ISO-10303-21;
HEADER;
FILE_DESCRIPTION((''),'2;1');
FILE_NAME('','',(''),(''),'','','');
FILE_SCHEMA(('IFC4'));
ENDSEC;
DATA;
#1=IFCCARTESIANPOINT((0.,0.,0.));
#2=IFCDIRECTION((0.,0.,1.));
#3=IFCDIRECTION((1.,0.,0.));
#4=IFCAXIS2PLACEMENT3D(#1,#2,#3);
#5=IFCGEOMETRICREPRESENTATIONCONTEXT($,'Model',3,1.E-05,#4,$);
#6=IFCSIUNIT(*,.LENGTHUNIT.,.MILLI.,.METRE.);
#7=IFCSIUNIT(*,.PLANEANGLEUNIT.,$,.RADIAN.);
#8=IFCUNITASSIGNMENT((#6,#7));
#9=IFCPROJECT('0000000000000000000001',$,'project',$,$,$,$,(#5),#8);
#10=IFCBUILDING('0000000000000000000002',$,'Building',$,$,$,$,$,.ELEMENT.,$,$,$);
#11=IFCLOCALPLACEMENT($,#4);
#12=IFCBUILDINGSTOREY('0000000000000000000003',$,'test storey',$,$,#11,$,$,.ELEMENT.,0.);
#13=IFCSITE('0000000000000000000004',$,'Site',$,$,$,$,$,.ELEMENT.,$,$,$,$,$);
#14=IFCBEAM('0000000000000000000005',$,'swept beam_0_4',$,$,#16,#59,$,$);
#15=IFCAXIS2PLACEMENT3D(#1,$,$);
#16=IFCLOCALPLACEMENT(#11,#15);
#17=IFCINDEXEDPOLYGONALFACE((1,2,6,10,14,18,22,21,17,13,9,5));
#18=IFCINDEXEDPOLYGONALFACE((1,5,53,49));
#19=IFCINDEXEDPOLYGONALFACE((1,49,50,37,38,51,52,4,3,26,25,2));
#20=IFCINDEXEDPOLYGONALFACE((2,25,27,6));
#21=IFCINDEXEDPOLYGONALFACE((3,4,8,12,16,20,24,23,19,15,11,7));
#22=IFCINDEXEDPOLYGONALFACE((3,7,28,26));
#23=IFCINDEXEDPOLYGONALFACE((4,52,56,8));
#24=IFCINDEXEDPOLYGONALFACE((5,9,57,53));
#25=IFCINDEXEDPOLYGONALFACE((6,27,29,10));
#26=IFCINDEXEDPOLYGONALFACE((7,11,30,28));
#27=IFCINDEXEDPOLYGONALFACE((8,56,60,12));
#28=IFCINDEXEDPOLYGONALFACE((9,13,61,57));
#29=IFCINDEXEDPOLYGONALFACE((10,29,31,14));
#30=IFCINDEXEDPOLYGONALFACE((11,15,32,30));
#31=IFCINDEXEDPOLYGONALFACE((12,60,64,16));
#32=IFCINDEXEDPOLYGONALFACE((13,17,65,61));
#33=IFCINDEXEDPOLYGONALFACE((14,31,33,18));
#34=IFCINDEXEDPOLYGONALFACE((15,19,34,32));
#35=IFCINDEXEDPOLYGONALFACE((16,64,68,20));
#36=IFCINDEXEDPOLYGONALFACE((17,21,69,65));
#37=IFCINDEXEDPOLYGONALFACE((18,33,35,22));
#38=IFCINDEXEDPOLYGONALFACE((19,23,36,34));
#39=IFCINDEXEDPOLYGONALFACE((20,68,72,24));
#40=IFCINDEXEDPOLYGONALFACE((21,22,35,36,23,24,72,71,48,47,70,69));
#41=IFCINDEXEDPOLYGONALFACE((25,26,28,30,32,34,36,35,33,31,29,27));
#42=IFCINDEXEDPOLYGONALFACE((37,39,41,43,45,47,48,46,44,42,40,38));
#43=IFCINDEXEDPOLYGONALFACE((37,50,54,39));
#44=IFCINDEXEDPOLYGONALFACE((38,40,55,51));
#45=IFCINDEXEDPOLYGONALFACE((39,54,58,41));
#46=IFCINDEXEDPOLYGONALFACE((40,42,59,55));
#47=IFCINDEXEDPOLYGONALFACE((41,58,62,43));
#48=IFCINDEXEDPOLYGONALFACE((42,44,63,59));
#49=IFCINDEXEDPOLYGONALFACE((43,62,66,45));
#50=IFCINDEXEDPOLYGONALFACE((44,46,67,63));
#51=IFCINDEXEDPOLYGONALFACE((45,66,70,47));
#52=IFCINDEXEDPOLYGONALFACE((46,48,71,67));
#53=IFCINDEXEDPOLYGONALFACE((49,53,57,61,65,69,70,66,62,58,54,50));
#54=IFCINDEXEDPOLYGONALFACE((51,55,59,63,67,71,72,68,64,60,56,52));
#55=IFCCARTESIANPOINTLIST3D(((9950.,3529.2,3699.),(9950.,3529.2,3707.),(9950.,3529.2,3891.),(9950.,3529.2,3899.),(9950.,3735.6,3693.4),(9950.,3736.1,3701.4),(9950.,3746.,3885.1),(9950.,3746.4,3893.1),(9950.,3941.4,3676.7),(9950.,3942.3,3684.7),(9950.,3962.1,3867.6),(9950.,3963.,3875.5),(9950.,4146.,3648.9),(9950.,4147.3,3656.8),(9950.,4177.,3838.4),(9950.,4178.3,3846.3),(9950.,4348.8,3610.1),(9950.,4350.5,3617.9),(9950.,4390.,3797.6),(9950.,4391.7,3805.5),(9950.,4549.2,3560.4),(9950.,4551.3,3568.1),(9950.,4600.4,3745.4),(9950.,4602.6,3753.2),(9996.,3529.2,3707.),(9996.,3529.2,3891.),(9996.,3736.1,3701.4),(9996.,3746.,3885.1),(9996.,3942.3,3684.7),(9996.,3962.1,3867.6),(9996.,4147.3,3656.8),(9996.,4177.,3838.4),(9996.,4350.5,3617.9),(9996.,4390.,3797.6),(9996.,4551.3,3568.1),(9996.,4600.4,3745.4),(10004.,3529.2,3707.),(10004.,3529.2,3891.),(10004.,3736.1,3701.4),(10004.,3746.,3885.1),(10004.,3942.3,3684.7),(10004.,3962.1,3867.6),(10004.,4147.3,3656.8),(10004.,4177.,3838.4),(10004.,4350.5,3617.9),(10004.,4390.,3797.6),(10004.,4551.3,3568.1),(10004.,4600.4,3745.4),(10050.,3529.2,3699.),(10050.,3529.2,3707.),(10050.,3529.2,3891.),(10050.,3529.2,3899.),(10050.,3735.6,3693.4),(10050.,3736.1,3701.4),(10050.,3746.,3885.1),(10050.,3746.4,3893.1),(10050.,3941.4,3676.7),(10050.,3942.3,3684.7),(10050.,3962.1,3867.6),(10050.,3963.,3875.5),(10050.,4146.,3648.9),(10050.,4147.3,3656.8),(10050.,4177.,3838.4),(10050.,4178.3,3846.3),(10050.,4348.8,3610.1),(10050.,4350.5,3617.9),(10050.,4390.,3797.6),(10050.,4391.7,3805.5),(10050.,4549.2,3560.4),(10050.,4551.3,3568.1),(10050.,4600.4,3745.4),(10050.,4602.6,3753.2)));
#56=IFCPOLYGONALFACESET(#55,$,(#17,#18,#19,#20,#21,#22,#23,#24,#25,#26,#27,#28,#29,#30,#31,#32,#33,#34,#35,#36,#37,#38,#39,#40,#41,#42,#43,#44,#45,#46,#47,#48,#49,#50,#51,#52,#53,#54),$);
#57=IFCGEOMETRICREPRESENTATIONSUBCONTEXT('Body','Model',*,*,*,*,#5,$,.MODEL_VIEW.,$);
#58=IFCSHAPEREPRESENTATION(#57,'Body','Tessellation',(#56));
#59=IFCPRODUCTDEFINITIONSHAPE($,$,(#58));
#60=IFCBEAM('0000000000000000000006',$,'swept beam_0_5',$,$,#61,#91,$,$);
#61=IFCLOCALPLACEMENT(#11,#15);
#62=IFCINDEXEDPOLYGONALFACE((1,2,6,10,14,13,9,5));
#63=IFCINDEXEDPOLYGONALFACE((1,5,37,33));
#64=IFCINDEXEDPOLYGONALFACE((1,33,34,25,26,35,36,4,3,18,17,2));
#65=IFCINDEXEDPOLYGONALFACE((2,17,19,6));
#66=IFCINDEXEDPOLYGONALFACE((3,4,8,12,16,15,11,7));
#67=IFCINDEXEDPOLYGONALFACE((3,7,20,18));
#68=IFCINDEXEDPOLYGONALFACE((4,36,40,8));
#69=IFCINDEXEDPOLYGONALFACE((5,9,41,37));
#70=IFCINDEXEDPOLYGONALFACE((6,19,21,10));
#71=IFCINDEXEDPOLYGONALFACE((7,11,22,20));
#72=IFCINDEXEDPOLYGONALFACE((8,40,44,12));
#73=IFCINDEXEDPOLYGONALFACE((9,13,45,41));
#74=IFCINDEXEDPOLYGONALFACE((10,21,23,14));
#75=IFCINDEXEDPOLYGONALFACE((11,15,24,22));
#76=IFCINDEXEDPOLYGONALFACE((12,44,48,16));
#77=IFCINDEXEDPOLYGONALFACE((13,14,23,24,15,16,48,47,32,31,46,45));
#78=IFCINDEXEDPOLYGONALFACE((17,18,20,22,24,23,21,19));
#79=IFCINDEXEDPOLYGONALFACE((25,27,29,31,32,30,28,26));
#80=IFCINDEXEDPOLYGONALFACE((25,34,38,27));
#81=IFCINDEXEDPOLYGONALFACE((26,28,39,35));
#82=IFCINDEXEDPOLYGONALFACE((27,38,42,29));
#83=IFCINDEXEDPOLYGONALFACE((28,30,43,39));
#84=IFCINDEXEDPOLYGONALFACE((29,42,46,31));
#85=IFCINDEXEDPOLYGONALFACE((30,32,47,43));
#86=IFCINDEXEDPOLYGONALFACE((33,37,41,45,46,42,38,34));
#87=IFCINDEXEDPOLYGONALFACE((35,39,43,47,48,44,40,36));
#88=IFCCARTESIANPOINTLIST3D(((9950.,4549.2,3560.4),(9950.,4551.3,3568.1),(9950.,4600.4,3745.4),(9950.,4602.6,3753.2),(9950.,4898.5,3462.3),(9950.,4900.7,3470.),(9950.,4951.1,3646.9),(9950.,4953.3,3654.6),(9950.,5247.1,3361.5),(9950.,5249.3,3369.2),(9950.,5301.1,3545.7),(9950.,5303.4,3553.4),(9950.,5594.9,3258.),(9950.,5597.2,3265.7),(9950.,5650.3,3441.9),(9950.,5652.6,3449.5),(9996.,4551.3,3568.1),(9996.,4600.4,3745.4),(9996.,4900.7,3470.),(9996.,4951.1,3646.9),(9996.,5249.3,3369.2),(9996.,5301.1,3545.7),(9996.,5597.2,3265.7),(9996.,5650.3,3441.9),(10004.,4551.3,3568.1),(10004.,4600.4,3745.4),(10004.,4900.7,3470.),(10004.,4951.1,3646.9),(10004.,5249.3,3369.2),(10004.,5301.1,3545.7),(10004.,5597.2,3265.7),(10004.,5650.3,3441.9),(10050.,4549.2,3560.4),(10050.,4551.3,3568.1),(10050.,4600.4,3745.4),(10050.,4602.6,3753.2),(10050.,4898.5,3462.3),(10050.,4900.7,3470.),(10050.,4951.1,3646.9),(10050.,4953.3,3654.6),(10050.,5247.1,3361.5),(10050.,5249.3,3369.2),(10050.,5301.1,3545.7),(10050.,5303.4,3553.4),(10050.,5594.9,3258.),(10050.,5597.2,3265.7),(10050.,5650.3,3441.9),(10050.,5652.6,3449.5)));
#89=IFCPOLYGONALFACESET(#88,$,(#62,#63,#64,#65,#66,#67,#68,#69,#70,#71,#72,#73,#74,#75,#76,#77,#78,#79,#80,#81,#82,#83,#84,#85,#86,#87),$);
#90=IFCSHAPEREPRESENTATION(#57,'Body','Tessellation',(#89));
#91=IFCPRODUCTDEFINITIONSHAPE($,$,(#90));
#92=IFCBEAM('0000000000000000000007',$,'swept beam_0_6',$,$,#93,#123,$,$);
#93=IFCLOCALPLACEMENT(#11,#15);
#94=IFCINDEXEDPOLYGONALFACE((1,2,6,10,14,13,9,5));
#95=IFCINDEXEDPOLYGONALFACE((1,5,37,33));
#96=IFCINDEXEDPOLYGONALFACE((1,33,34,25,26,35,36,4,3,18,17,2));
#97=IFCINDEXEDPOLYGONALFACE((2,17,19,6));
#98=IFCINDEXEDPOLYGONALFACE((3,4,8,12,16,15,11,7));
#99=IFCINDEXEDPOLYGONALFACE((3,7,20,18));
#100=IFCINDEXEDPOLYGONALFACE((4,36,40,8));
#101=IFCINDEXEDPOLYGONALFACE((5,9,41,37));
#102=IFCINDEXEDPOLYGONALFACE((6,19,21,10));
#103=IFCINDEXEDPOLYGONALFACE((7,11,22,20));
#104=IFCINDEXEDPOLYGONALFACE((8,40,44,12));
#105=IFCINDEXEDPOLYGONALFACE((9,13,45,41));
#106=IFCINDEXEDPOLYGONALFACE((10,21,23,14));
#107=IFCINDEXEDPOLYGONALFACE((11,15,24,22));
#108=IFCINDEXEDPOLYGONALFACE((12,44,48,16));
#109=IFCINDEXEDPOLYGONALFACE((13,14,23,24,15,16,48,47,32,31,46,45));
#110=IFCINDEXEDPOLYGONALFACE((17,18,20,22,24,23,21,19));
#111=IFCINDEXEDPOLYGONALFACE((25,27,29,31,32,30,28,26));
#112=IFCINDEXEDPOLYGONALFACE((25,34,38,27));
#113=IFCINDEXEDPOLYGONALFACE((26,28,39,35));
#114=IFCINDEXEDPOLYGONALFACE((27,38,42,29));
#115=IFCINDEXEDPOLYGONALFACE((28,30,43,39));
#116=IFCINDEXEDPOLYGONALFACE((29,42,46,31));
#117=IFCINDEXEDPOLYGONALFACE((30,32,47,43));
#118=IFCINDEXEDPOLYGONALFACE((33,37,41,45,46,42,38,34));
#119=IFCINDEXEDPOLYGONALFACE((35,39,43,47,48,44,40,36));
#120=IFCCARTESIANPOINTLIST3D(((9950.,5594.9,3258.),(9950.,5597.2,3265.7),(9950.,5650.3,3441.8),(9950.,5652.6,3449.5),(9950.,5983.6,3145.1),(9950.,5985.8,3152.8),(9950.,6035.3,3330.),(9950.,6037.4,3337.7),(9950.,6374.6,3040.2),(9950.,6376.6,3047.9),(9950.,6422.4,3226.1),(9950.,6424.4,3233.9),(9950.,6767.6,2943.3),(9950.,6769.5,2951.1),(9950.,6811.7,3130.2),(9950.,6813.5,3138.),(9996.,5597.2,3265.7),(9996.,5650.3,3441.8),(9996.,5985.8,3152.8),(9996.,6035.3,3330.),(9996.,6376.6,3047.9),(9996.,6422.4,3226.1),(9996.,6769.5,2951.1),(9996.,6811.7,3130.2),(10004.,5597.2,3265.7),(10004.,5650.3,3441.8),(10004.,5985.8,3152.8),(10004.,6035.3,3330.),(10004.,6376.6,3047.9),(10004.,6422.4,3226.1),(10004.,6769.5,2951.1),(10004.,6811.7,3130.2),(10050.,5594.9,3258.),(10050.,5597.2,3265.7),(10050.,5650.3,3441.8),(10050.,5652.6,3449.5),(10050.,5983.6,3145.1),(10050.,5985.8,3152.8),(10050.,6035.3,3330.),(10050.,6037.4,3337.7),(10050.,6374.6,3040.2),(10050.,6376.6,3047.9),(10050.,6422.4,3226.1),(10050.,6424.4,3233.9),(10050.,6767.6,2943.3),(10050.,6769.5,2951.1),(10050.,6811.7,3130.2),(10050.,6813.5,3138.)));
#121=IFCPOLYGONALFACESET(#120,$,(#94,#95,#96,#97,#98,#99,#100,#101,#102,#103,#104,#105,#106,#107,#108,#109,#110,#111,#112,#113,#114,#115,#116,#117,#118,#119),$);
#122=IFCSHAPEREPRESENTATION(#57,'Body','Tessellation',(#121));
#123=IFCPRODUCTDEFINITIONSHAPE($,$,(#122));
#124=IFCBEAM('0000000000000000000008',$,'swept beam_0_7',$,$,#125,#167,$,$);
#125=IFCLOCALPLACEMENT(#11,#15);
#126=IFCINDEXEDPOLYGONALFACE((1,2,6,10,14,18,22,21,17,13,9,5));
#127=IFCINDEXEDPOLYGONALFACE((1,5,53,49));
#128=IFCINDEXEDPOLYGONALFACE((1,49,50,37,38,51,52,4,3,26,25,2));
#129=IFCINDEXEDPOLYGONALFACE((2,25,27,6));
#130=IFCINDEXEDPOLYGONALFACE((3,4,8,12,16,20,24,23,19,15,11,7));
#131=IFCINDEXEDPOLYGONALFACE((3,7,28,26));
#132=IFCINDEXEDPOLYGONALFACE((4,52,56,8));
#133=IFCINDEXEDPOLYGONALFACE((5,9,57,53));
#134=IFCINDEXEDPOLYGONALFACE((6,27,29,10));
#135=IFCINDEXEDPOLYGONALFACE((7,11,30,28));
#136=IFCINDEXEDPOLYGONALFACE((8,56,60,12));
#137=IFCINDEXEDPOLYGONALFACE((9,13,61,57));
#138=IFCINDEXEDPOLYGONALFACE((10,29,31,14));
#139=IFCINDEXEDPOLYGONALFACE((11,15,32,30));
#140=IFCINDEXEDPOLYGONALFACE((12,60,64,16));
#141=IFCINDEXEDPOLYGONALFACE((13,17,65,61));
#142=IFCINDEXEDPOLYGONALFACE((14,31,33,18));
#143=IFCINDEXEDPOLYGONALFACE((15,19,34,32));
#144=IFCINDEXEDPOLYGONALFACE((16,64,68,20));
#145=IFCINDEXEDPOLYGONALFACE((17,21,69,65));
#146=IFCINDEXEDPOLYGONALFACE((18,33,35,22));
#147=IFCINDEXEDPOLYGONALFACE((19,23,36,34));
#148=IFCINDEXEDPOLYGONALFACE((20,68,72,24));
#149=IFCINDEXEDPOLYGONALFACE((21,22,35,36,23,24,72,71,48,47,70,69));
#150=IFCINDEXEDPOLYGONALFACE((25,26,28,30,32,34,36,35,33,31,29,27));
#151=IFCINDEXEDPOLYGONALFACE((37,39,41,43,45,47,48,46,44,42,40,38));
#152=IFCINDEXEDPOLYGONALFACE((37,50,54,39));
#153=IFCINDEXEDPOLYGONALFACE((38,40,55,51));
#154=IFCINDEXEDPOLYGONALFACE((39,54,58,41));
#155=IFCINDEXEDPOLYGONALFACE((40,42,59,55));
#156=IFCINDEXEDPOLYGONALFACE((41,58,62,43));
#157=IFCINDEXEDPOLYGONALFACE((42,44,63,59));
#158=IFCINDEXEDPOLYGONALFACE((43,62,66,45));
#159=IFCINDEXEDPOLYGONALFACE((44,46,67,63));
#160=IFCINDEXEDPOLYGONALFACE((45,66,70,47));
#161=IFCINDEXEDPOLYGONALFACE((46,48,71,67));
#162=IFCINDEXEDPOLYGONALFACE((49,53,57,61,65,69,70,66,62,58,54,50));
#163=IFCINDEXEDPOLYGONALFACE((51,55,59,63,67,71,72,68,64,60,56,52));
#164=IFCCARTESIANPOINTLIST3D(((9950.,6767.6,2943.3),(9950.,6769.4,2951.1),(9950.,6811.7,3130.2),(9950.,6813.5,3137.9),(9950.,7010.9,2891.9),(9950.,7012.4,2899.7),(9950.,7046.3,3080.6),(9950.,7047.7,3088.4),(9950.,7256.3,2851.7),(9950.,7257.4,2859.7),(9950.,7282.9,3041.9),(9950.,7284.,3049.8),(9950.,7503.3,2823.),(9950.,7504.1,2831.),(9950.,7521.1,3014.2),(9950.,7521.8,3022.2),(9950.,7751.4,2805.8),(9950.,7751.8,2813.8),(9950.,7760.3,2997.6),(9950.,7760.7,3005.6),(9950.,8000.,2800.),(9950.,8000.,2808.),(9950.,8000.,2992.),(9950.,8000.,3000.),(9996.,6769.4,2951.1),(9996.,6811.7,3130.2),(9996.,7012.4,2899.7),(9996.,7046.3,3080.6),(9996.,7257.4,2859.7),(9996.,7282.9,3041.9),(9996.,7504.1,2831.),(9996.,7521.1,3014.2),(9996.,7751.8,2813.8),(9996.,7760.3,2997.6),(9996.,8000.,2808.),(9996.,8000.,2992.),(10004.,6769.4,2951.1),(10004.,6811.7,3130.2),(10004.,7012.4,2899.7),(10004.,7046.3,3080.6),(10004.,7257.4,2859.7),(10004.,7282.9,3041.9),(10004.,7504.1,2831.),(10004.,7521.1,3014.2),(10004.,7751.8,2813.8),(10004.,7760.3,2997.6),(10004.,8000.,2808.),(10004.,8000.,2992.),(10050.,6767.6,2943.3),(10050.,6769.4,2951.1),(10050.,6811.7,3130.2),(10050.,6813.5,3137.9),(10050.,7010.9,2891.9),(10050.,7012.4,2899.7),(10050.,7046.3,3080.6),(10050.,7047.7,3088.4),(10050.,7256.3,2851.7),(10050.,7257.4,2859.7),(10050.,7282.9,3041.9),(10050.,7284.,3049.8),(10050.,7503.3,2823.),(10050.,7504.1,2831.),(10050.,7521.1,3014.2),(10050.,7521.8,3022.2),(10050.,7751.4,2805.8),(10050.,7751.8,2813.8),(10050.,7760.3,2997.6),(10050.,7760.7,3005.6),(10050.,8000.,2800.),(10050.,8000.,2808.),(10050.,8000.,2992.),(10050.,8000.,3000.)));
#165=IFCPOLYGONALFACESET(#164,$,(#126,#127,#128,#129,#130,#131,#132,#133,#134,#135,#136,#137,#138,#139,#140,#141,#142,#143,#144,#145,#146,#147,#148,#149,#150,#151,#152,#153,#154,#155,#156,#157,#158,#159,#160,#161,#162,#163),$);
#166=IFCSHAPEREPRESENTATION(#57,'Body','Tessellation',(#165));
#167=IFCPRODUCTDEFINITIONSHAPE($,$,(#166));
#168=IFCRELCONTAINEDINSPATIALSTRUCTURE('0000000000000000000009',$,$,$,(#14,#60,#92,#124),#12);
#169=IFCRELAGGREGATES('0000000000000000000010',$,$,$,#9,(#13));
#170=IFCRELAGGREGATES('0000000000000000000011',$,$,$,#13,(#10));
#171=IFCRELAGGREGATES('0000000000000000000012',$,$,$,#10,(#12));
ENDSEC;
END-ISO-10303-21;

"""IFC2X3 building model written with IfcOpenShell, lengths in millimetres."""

from ifc_helpers import new_model, entity, si_unit, origin_with_axes, place, context, subcontext, project, spatial, element, save


model = new_model("IFC2X3")

# Units and contexts
model_context = context("Model", 3, precision=1e-05, world=origin_with_axes())
body_context = subcontext(model_context, "Body", "Model", "MODEL_VIEW")
ifc_project = project(units=[si_unit("LENGTHUNIT", "METRE", prefix="MILLI"), si_unit("PLANEANGLEUNIT", "RADIAN")], contexts=[model_context])

# Site, building, storey
site = spatial("IfcSite", under=ifc_project, Name="Site", CompositionType="ELEMENT")
building = spatial("IfcBuilding", under=site, Name="Building", CompositionType="ELEMENT")
storey_placement = place(None, origin_with_axes())
storey = spatial("IfcBuildingStorey", under=building, at=storey_placement, Name="test storey", CompositionType="ELEMENT", Elevation=0.0)

# Beams
beam_1_placement = place(storey_placement, origin_with_axes())
element("IfcBeam", 1, at=beam_1_placement, inside=storey, Name="swept beam_0_4", context=body_context, shape_type="SweptSolid", body=[
    entity("IfcRevolvedAreaSolid", entity("IfcArbitraryClosedProfileDef", "AREA", None, entity("IfcPolyline", [entity("IfcCartesianPoint", [-192.0, -50.0]), entity("IfcCartesianPoint", [-192.0, -4.0]), entity("IfcCartesianPoint", [-8.0, -4.0]), entity("IfcCartesianPoint", [-8.0, -50.0]), entity("IfcCartesianPoint", [0.0, -50.0]), entity("IfcCartesianPoint", [0.0, 50.0]), entity("IfcCartesianPoint", [-8.0, 50.0]), entity("IfcCartesianPoint", [-8.0, 4.0]), entity("IfcCartesianPoint", [-192.0, 4.0]), entity("IfcCartesianPoint", [-192.0, 50.0]), entity("IfcCartesianPoint", [-200.0, 50.0]), entity("IfcCartesianPoint", [-200.0, -50.0]), entity("IfcCartesianPoint", [-192.0, -50.0])])), entity("IfcAxis2Placement3D", entity("IfcCartesianPoint", [10000.0, 3529.2, 3899.0]), entity("IfcDirection", [0.0, -1.0, 0.0]), entity("IfcDirection", [0.0, 0.0, 1.0])), entity("IfcAxis1Placement", entity("IfcCartesianPoint", [-4022.2, 0.0, 0.0]), entity("IfcDirection", [0.0, 1.0, 0.0])), 0.270117),
])
beam_2_placement = place(storey_placement, origin_with_axes())
element("IfcBeam", 2, at=beam_2_placement, inside=storey, Name="swept beam_0_5", context=body_context, shape_type="SweptSolid", body=[
    entity("IfcRevolvedAreaSolid", entity("IfcArbitraryClosedProfileDef", "AREA", None, entity("IfcPolyline", [entity("IfcCartesianPoint", [-192.0, -50.0]), entity("IfcCartesianPoint", [-192.0, -4.0]), entity("IfcCartesianPoint", [-8.0, -4.0]), entity("IfcCartesianPoint", [-8.0, -50.0]), entity("IfcCartesianPoint", [0.0, -50.0]), entity("IfcCartesianPoint", [0.0, 50.0]), entity("IfcCartesianPoint", [-8.0, 50.0]), entity("IfcCartesianPoint", [-8.0, 4.0]), entity("IfcCartesianPoint", [-192.0, 4.0]), entity("IfcCartesianPoint", [-192.0, 50.0]), entity("IfcCartesianPoint", [-200.0, 50.0]), entity("IfcCartesianPoint", [-200.0, -50.0]), entity("IfcCartesianPoint", [-192.0, -50.0])])), entity("IfcAxis2Placement3D", entity("IfcCartesianPoint", [10000.0, 4602.6, 3753.2]), entity("IfcDirection", [0.0, -0.9637, 0.2668]), entity("IfcDirection", [0.0, 0.2668, 0.9637])), entity("IfcAxis1Placement", entity("IfcCartesianPoint", [-47997.1, 0.0, 0.0]), entity("IfcDirection", [0.0, 1.0, 0.0])), 0.022774),
])
beam_3_placement = place(storey_placement, origin_with_axes())
element("IfcBeam", 3, at=beam_3_placement, inside=storey, Name="swept beam_0_6", context=body_context, shape_type="SweptSolid", body=[
    entity("IfcRevolvedAreaSolid", entity("IfcArbitraryClosedProfileDef", "AREA", None, entity("IfcPolyline", [entity("IfcCartesianPoint", [192.0, 50.0]), entity("IfcCartesianPoint", [192.0, 4.0]), entity("IfcCartesianPoint", [8.0, 4.0]), entity("IfcCartesianPoint", [8.0, 50.0]), entity("IfcCartesianPoint", [0.0, 50.0]), entity("IfcCartesianPoint", [0.0, -50.0]), entity("IfcCartesianPoint", [8.0, -50.0]), entity("IfcCartesianPoint", [8.0, -4.0]), entity("IfcCartesianPoint", [192.0, -4.0]), entity("IfcCartesianPoint", [192.0, -50.0]), entity("IfcCartesianPoint", [200.0, -50.0]), entity("IfcCartesianPoint", [200.0, 50.0]), entity("IfcCartesianPoint", [192.0, 50.0])])), entity("IfcAxis2Placement3D", entity("IfcCartesianPoint", [10000.0, 5652.6, 3449.5]), entity("IfcDirection", [0.0, -0.9574, 0.2887]), entity("IfcDirection", [0.0, -0.2887, -0.9574])), entity("IfcAxis1Placement", entity("IfcCartesianPoint", [-19579.5, 0.0, 0.0]), entity("IfcDirection", [0.0, 1.0, 0.0])), 0.061399),
])
beam_4_placement = place(storey_placement, origin_with_axes())
element("IfcBeam", 4, at=beam_4_placement, inside=storey, Name="swept beam_0_7", context=body_context, shape_type="SweptSolid", body=[
    entity("IfcRevolvedAreaSolid", entity("IfcArbitraryClosedProfileDef", "AREA", None, entity("IfcPolyline", [entity("IfcCartesianPoint", [192.0, 50.0]), entity("IfcCartesianPoint", [192.0, 4.0]), entity("IfcCartesianPoint", [8.0, 4.0]), entity("IfcCartesianPoint", [8.0, 50.0]), entity("IfcCartesianPoint", [0.0, 50.0]), entity("IfcCartesianPoint", [0.0, -50.0]), entity("IfcCartesianPoint", [8.0, -50.0]), entity("IfcCartesianPoint", [8.0, -4.0]), entity("IfcCartesianPoint", [192.0, -4.0]), entity("IfcCartesianPoint", [192.0, -50.0]), entity("IfcCartesianPoint", [200.0, -50.0]), entity("IfcCartesianPoint", [200.0, 50.0]), entity("IfcCartesianPoint", [192.0, 50.0])])), entity("IfcAxis2Placement3D", entity("IfcCartesianPoint", [10000.0, 6813.5, 3137.9]), entity("IfcDirection", [0.0, -0.9733, 0.2294]), entity("IfcDirection", [0.0, -0.2294, -0.9733])), entity("IfcAxis1Placement", entity("IfcCartesianPoint", [-5171.5, 0.0, 0.0]), entity("IfcDirection", [0.0, 1.0, 0.0])), 0.231492),
])

save(model, "model.ifc")
